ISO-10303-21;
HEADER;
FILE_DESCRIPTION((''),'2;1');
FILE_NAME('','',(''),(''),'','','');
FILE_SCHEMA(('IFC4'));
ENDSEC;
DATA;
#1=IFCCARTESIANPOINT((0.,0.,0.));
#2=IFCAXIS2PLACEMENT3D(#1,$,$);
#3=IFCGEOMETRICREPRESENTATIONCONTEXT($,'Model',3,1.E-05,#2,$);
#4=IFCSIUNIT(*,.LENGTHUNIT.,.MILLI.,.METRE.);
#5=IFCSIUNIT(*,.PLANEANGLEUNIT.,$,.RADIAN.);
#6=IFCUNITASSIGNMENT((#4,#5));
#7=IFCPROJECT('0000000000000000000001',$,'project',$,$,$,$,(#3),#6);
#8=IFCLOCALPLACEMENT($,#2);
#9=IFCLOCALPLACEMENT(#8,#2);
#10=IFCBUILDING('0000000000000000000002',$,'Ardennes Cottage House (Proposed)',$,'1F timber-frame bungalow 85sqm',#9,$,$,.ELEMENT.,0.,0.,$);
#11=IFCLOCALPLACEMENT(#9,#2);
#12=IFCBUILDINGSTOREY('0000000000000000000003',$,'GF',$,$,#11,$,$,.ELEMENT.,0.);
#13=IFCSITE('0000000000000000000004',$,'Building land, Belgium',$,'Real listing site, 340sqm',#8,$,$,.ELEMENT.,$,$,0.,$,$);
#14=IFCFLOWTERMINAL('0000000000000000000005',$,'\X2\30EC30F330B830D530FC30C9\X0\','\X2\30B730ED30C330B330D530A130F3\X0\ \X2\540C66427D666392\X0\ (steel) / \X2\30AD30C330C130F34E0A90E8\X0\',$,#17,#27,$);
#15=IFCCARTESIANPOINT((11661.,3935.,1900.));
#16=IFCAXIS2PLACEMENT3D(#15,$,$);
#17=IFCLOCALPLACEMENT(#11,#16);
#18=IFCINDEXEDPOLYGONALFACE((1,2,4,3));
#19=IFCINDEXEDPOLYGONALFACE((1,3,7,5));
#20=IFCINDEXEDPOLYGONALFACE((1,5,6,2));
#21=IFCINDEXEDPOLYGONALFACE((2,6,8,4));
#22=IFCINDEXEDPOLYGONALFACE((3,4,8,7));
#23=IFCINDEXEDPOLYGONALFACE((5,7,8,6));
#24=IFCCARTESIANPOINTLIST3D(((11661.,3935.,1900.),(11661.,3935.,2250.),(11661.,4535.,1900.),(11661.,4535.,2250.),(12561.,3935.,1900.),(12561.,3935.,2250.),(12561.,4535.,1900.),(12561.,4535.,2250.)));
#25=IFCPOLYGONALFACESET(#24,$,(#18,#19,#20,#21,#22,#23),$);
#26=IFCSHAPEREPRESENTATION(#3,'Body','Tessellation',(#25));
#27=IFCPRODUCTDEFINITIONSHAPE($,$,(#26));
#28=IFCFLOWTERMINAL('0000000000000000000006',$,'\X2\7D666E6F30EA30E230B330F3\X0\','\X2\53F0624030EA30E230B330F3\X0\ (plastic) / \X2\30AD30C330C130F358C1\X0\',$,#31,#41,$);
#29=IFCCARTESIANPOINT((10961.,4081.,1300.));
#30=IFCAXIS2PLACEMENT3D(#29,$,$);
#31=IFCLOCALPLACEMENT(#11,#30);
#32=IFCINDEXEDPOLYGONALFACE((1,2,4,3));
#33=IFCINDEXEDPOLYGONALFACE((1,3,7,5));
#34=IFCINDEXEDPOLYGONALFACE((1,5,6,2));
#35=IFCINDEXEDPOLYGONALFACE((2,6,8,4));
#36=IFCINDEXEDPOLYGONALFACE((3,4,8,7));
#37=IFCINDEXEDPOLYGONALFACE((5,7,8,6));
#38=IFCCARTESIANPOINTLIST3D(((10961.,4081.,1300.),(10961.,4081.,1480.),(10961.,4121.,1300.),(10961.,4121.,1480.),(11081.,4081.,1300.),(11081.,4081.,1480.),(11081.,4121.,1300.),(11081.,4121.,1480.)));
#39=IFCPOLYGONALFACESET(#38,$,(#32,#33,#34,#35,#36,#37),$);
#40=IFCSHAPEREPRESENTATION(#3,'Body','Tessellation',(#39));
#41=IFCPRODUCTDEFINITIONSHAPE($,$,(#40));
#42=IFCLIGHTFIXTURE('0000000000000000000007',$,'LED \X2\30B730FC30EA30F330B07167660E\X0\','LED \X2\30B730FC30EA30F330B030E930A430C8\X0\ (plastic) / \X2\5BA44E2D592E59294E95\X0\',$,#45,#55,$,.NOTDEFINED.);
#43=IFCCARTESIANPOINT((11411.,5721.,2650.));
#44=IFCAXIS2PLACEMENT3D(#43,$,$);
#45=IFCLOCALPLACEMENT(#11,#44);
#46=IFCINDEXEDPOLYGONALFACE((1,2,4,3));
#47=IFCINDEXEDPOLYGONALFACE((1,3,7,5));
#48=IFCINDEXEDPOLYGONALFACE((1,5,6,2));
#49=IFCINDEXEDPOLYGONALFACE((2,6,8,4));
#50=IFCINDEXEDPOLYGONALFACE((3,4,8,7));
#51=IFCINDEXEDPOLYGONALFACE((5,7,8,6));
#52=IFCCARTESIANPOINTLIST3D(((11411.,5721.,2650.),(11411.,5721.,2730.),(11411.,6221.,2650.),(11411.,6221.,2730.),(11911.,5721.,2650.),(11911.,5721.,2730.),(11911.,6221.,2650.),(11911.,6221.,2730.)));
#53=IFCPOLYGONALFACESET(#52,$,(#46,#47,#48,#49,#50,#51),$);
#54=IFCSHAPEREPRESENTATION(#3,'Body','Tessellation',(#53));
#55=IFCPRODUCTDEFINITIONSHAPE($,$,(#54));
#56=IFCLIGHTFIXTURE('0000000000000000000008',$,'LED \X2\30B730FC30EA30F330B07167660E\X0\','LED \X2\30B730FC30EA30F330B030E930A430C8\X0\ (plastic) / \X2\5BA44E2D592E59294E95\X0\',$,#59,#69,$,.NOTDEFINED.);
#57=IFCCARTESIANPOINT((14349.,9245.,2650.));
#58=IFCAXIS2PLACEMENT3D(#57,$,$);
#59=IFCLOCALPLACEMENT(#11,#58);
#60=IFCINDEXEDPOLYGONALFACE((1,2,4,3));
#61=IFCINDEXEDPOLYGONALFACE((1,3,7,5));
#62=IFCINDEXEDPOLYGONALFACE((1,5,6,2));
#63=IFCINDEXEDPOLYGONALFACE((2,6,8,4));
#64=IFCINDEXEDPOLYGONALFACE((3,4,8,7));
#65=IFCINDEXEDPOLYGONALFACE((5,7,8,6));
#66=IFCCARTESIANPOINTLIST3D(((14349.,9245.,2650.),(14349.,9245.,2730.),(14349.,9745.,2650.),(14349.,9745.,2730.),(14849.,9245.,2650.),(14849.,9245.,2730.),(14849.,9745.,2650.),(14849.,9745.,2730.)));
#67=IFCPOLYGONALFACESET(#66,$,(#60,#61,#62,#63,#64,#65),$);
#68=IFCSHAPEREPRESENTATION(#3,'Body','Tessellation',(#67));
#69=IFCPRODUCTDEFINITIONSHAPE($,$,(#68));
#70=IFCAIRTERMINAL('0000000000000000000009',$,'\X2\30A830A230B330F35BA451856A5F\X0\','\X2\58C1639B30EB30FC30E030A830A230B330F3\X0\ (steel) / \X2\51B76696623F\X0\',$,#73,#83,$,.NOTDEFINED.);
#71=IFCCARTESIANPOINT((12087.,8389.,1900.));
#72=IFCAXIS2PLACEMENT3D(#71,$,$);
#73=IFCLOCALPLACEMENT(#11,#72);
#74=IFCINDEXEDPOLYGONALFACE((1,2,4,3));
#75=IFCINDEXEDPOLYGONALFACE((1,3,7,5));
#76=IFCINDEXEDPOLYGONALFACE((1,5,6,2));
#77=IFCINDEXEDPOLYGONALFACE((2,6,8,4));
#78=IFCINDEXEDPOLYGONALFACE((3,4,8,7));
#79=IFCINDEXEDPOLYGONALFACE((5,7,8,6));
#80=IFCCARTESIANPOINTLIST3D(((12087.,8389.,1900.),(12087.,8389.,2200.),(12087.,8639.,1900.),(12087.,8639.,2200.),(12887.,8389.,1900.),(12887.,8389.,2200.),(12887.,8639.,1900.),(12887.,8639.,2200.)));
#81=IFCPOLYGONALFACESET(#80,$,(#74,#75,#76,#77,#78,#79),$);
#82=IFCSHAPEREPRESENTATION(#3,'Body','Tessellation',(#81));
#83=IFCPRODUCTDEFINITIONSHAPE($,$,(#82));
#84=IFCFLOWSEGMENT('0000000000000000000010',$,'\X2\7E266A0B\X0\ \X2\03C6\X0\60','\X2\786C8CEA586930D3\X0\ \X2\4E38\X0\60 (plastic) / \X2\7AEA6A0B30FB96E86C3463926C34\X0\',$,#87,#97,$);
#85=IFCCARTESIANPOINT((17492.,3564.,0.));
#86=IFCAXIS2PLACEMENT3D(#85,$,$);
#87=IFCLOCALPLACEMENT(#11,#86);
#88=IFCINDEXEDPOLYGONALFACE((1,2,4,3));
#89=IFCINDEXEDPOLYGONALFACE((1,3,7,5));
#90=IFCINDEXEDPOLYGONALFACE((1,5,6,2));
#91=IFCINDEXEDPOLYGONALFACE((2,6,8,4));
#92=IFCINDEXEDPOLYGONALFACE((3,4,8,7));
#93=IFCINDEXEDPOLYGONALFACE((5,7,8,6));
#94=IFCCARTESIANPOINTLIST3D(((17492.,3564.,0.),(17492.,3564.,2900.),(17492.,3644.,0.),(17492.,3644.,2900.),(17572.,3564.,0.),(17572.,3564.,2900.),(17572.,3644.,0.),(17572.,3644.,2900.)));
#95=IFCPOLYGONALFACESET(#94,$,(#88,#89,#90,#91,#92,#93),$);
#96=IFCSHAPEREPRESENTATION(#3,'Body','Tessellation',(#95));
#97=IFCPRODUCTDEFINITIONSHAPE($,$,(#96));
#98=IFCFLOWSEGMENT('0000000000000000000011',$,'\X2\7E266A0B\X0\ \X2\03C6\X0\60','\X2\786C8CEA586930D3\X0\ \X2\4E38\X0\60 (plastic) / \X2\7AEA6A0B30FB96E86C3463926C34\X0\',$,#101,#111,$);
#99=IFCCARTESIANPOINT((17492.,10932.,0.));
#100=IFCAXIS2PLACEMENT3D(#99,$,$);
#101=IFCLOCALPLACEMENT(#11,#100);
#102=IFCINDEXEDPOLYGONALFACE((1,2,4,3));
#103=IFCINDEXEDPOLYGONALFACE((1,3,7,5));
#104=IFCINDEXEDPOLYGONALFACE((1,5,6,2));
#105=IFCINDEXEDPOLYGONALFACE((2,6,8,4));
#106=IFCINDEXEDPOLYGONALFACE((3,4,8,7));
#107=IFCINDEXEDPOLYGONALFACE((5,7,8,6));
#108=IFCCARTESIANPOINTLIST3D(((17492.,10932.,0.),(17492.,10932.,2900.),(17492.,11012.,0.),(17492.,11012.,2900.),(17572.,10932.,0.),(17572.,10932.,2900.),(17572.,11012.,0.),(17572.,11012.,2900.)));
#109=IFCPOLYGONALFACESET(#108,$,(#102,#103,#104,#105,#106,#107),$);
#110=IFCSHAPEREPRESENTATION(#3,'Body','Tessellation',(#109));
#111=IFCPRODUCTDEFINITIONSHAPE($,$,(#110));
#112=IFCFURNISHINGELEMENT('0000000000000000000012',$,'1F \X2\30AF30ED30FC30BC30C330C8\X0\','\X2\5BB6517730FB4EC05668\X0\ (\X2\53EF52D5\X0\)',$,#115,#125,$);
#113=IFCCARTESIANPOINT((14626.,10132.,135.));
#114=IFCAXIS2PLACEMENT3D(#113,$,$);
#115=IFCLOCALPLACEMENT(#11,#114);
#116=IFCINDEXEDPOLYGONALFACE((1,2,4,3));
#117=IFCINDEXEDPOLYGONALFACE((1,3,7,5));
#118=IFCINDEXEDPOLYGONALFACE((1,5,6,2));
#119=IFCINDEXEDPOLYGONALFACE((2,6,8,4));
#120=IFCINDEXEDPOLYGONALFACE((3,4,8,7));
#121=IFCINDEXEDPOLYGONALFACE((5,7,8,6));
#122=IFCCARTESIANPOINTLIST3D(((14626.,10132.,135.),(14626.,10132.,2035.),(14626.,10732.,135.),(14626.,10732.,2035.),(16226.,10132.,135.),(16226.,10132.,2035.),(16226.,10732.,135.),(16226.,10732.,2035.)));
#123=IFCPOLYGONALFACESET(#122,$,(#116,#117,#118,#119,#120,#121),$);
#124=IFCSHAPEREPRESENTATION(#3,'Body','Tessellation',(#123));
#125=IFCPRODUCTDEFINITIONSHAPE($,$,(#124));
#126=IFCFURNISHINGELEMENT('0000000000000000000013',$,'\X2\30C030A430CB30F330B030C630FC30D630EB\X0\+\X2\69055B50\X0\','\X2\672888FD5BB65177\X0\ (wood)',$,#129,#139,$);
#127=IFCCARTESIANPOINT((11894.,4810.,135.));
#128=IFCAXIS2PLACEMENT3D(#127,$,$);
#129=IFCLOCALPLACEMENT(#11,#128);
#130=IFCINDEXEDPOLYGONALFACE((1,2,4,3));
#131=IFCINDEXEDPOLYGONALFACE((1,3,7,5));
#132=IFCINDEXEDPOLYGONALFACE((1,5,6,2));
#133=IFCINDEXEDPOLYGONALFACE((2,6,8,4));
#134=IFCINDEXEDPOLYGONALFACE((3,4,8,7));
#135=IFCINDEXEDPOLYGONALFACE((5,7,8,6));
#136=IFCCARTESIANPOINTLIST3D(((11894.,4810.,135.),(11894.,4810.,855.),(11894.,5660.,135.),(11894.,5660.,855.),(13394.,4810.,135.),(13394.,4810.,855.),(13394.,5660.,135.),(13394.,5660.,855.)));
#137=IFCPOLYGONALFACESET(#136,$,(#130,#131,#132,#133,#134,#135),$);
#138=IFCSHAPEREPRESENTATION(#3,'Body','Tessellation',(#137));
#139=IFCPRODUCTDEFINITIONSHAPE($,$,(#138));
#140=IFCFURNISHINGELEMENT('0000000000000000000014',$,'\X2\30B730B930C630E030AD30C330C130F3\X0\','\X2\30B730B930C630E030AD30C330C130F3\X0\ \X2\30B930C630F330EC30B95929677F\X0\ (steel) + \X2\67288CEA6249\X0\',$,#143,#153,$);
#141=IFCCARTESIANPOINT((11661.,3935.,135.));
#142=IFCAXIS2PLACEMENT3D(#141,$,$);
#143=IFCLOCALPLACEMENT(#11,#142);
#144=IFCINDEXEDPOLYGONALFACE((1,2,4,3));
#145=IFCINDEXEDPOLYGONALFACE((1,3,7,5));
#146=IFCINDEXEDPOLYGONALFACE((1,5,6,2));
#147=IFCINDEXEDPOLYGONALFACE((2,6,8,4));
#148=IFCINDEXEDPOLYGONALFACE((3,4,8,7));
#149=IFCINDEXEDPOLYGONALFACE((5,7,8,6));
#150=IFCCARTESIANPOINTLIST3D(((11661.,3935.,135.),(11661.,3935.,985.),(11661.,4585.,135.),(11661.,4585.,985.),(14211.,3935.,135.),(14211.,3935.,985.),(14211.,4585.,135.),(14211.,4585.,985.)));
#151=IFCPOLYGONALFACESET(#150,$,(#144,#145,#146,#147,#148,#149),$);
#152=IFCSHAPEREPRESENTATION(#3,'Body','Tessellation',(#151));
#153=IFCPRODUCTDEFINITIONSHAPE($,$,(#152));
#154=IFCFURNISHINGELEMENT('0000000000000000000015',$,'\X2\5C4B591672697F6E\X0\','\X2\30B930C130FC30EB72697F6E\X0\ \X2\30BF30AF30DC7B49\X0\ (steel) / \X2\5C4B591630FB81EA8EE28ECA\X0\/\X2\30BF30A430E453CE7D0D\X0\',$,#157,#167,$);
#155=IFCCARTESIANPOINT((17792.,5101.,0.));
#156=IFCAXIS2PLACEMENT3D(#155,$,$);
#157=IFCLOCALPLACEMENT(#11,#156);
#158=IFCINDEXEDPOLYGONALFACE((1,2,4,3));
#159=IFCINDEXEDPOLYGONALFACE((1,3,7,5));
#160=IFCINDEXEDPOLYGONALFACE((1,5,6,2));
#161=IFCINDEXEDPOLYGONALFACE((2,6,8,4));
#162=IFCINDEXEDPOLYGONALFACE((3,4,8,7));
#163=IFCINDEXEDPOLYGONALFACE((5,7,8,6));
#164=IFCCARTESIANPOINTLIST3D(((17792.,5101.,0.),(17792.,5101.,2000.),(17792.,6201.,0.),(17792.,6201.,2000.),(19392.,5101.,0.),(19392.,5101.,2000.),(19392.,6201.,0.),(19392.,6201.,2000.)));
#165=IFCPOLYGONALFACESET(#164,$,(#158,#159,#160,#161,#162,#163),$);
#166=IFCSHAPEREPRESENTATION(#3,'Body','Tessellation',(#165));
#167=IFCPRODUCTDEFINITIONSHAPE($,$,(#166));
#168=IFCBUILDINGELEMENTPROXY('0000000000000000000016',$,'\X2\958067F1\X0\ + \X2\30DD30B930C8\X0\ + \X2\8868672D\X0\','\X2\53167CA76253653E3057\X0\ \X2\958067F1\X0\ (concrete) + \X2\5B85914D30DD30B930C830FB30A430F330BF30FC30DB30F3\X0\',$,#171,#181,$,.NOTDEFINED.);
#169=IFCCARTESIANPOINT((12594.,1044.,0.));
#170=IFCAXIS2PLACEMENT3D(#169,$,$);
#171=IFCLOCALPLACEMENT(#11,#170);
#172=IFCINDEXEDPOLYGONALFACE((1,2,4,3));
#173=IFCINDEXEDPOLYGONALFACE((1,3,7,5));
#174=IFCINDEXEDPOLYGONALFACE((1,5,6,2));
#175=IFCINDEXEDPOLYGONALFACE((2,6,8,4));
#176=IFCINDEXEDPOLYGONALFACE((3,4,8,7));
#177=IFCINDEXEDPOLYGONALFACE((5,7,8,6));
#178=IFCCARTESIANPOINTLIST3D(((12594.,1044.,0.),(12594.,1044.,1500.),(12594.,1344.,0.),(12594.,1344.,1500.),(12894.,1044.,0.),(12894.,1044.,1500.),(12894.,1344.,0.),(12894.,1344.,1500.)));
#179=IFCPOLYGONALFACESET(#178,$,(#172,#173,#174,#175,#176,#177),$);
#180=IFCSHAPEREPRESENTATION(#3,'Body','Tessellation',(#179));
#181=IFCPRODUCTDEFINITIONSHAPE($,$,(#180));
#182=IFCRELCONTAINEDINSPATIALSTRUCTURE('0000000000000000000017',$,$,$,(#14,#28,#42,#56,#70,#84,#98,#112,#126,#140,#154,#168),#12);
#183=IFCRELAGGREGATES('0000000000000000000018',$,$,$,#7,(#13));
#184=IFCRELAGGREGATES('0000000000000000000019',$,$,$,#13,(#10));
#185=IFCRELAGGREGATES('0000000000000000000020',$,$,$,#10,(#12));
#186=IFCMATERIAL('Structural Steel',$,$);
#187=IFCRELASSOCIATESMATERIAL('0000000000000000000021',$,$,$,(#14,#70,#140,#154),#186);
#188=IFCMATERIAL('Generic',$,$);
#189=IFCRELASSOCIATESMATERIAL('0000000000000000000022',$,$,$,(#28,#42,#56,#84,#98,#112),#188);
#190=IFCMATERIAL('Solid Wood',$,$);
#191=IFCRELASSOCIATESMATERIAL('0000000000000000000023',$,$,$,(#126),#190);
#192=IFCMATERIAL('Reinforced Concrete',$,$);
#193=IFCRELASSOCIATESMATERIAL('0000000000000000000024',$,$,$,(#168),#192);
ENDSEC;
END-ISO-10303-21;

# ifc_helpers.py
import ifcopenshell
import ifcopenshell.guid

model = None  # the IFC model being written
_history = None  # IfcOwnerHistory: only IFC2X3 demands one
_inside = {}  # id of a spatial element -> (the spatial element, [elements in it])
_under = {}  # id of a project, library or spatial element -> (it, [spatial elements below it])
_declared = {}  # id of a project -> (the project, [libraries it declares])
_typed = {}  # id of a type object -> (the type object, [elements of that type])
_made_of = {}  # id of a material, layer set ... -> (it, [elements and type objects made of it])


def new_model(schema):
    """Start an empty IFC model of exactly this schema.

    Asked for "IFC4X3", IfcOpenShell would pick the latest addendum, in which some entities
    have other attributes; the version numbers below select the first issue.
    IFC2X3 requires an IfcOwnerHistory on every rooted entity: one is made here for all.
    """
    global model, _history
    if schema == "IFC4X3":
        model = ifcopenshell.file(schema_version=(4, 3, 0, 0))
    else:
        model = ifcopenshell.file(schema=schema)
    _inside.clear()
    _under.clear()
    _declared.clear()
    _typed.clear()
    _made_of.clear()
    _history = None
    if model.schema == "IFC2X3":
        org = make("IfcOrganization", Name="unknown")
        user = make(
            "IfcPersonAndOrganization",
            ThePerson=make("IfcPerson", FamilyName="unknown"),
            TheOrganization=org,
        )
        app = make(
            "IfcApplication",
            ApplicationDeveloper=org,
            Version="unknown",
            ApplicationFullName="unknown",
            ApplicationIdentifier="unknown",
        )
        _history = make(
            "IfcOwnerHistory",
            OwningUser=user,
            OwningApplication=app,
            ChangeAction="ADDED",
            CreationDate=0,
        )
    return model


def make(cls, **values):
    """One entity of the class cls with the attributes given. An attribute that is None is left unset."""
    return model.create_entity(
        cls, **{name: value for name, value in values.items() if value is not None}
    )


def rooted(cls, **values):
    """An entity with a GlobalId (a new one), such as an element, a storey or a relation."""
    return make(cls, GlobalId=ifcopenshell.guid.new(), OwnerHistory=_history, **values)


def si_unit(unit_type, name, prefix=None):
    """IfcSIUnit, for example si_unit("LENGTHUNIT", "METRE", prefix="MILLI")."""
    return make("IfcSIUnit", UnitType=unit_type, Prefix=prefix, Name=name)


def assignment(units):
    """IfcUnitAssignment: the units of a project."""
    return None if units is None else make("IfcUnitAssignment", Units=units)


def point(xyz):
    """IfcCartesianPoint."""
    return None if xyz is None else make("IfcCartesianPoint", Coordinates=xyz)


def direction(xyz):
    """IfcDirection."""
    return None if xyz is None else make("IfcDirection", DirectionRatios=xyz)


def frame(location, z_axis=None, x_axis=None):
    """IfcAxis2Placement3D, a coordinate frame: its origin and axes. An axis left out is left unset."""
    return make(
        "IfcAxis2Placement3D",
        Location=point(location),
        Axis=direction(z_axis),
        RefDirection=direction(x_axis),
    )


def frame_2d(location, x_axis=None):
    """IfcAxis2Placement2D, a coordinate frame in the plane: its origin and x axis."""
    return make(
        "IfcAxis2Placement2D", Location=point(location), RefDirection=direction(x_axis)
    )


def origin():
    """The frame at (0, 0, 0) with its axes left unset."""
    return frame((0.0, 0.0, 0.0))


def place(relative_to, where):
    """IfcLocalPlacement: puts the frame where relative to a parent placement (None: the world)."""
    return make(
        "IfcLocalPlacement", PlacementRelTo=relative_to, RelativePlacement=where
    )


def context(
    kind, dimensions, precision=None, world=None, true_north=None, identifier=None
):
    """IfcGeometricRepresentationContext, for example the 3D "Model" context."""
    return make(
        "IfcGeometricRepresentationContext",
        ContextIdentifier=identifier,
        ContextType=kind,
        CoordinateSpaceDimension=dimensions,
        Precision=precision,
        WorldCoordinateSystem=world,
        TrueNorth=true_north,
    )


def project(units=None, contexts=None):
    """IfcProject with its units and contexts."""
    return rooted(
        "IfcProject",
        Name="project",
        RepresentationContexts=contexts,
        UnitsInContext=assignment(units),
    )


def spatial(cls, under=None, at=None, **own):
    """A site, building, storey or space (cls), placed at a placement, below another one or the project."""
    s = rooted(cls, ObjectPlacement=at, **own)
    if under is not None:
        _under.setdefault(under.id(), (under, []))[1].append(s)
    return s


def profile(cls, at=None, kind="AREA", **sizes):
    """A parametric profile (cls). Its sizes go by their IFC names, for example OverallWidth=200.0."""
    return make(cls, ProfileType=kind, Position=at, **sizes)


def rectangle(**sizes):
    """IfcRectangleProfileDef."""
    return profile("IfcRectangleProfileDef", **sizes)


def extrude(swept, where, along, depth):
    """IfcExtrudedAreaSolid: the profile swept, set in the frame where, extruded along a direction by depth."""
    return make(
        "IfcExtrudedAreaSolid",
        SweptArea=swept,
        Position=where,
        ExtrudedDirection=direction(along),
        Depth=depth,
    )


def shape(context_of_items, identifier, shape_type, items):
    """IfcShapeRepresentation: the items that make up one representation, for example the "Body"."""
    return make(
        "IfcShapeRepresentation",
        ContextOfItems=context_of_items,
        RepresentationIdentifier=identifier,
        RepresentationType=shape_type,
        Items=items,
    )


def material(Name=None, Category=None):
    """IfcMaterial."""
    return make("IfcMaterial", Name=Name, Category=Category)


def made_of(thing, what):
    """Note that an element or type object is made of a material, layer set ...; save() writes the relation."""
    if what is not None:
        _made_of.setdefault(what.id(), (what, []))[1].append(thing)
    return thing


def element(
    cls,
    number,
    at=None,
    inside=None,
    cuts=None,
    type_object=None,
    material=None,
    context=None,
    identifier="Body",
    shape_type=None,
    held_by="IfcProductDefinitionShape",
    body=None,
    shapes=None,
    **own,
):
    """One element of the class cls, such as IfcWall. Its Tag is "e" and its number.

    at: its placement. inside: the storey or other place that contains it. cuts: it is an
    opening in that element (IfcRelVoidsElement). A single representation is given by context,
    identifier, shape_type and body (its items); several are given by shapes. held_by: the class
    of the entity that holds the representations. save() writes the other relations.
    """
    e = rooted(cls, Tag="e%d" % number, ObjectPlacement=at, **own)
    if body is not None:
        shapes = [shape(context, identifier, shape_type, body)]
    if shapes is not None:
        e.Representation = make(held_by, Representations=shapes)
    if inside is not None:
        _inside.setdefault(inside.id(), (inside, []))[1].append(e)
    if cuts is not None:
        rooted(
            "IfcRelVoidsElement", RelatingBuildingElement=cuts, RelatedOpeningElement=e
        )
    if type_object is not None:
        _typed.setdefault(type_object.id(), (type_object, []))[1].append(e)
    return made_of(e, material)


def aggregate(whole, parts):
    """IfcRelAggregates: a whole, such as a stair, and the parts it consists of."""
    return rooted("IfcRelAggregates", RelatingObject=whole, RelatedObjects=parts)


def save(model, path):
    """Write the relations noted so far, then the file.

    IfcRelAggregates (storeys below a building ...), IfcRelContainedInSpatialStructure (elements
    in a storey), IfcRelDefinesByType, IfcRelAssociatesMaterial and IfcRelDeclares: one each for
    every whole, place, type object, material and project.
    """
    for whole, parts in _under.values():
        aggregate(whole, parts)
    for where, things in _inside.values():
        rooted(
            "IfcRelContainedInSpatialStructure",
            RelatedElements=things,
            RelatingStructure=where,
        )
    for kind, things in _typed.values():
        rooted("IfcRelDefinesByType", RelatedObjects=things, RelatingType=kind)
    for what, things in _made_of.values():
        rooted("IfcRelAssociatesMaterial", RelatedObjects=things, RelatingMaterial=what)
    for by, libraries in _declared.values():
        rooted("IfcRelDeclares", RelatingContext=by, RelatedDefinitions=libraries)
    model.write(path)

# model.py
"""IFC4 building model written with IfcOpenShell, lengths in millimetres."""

from ifc_helpers import new_model, si_unit, frame, frame_2d, origin, place, context, project, spatial, rectangle, extrude, material, element, save


model = new_model("IFC4")

# Units and contexts
model_context = context("Model", 3, precision=1e-05, world=origin())
ifc_project = project(units=[si_unit("LENGTHUNIT", "METRE", prefix="MILLI"), si_unit("PLANEANGLEUNIT", "RADIAN")], contexts=[model_context])

# Site, building, storey
site_placement = place(None, origin())
site = spatial("IfcSite", under=ifc_project, at=site_placement, Name="Building land, Belgium", ObjectType="Real listing site, 340sqm", CompositionType="ELEMENT", RefElevation=0.0)
building_placement = place(site_placement, origin())
building = spatial("IfcBuilding", under=site, at=building_placement, Name="Ardennes Cottage House (Proposed)", ObjectType="1F timber-frame bungalow 85sqm", CompositionType="ELEMENT", ElevationOfRefHeight=0.0, ElevationOfTerrain=0.0)
storey_placement = place(building_placement, origin())
storey = spatial("IfcBuildingStorey", under=building, at=storey_placement, Name="GF", CompositionType="ELEMENT", Elevation=0.0)

# Shared definitions
ifc_material_1 = material(Name="Solid Wood")

# Shared definitions
ifc_material_2 = material(Name="Reinforced Concrete")

# Shared definitions
ifc_material_3 = material(Name="Generic")

# Shared definitions
ifc_material_4 = material(Name="Structural Steel")

# Flow terminals
flow_terminal_1_placement = place(storey_placement, frame((11661.0, 3935.0, 1900.0)))
element("IfcFlowTerminal", 1, at=flow_terminal_1_placement, inside=storey, material=ifc_material_4, Name="レンジフード", Description="シロッコファン 同時給排 (steel) / キッチン上部", context=model_context, shape_type="SweptSolid", body=[
    extrude(rectangle(XDim=900.0, YDim=600.0, at=frame_2d((450.0, 300.0))), frame((11661.0, 3935.0, 1900.0)), (0.0, 0.0, 1.0), 350.0),
])
flow_terminal_2_placement = place(storey_placement, frame((10961.0, 4081.0, 1300.0)))
element("IfcFlowTerminal", 2, at=flow_terminal_2_placement, inside=storey, material=ifc_material_3, Name="給湯リモコン", Description="台所リモコン (plastic) / キッチン壁", context=model_context, shape_type="SweptSolid", body=[
    extrude(rectangle(XDim=120.0, YDim=40.0, at=frame_2d((60.0, 20.0))), frame((10961.0, 4081.0, 1300.0)), (0.0, 0.0, 1.0), 180.0),
])

# Light fixtures
light_fixture_1_placement = place(storey_placement, frame((11411.0, 5721.0, 2650.0)))
element("IfcLightFixture", 3, at=light_fixture_1_placement, inside=storey, material=ifc_material_3, Name="LED シーリング照明", Description="LED シーリングライト (plastic) / 室中央天井", PredefinedType="NOTDEFINED", context=model_context, shape_type="SweptSolid", body=[
    extrude(rectangle(XDim=500.0, YDim=500.0, at=frame_2d((250.0, 250.0))), frame((11411.0, 5721.0, 2650.0)), (0.0, 0.0, 1.0), 80.0),
])
light_fixture_2_placement = place(storey_placement, frame((14349.0, 9245.0, 2650.0)))
element("IfcLightFixture", 4, at=light_fixture_2_placement, inside=storey, material=ifc_material_3, Name="LED シーリング照明", Description="LED シーリングライト (plastic) / 室中央天井", PredefinedType="NOTDEFINED", context=model_context, shape_type="SweptSolid", body=[
    extrude(rectangle(XDim=500.0, YDim=500.0, at=frame_2d((250.0, 250.0))), frame((14349.0, 9245.0, 2650.0)), (0.0, 0.0, 1.0), 80.0),
])

# Air terminal
air_terminal_placement = place(storey_placement, frame((12087.0, 8389.0, 1900.0)))
element("IfcAirTerminal", 5, at=air_terminal_placement, inside=storey, material=ifc_material_4, Name="エアコン室内機", Description="壁掛ルームエアコン (steel) / 冷暖房", PredefinedType="NOTDEFINED", context=model_context, shape_type="SweptSolid", body=[
    extrude(rectangle(XDim=800.0, YDim=250.0, at=frame_2d((400.0, 125.0))), frame((12087.0, 8389.0, 1900.0)), (0.0, 0.0, 1.0), 300.0),
])

# Flow segments
flow_segment_1_placement = place(storey_placement, frame((17492.0, 3564.0, 0.0)))
element("IfcFlowSegment", 6, at=flow_segment_1_placement, inside=storey, material=ifc_material_3, Name="縦樋 φ60", Description="硬質塩ビ 丸60 (plastic) / 竪樋・雨水排水", context=model_context, shape_type="SweptSolid", body=[
    extrude(rectangle(XDim=80.0, YDim=80.0, at=frame_2d((40.0, 40.0))), frame((17492.0, 3564.0, 0.0)), (0.0, 0.0, 1.0), 2900.0),
])
flow_segment_2_placement = place(storey_placement, frame((17492.0, 10932.0, 0.0)))
element("IfcFlowSegment", 7, at=flow_segment_2_placement, inside=storey, material=ifc_material_3, Name="縦樋 φ60", Description="硬質塩ビ 丸60 (plastic) / 竪樋・雨水排水", context=model_context, shape_type="SweptSolid", body=[
    extrude(rectangle(XDim=80.0, YDim=80.0, at=frame_2d((40.0, 40.0))), frame((17492.0, 10932.0, 0.0)), (0.0, 0.0, 1.0), 2900.0),
])

# Furnishing elements
furnishing_1_placement = place(storey_placement, frame((14626.0, 10132.0, 135.0)))
element("IfcFurnishingElement", 8, at=furnishing_1_placement, inside=storey, material=ifc_material_3, Name="1F クローゼット", Description="家具・什器 (可動)", context=model_context, shape_type="SweptSolid", body=[
    extrude(rectangle(XDim=1600.0, YDim=600.0, at=frame_2d((800.0, 300.0))), frame((14626.0, 10132.0, 135.0)), (0.0, 0.0, 1.0), 1900.0),
])
furnishing_2_placement = place(storey_placement, frame((11894.0, 4810.0, 135.0)))
element("IfcFurnishingElement", 9, at=furnishing_2_placement, inside=storey, material=ifc_material_1, Name="ダイニングテーブル+椅子", Description="木製家具 (wood)", context=model_context, shape_type="SweptSolid", body=[
    extrude(rectangle(XDim=1500.0, YDim=850.0, at=frame_2d((750.0, 425.0))), frame((11894.0, 4810.0, 135.0)), (0.0, 0.0, 1.0), 720.0),
])
furnishing_3_placement = place(storey_placement, frame((11661.0, 3935.0, 135.0)))
element("IfcFurnishingElement", 10, at=furnishing_3_placement, inside=storey, material=ifc_material_4, Name="システムキッチン", Description="システムキッチン ステンレス天板 (steel) + 木質扉", context=model_context, shape_type="SweptSolid", body=[
    extrude(rectangle(XDim=2550.0, YDim=650.0, at=frame_2d((1275.0, 325.0))), frame((11661.0, 3935.0, 135.0)), (0.0, 0.0, 1.0), 850.0),
])
furnishing_4_placement = place(storey_placement, frame((17792.0, 5101.0, 0.0)))
element("IfcFurnishingElement", 11, at=furnishing_4_placement, inside=storey, material=ifc_material_4, Name="屋外物置", Description="スチール物置 タクボ等 (steel) / 屋外・自転車/タイヤ収納", context=model_context, shape_type="SweptSolid", body=[
    extrude(rectangle(XDim=1600.0, YDim=1100.0, at=frame_2d((800.0, 550.0))), frame((17792.0, 5101.0, 0.0)), (0.0, 0.0, 1.0), 2000.0),
])

# Building element proxy
proxy_placement = place(storey_placement, frame((12594.0, 1044.0, 0.0)))
element("IfcBuildingElementProxy", 12, at=proxy_placement, inside=storey, material=ifc_material_2, Name="門柱 + ポスト + 表札", Description="化粧打放し 門柱 (concrete) + 宅配ポスト・インターホン", PredefinedType="NOTDEFINED", context=model_context, shape_type="SweptSolid", body=[
    extrude(rectangle(XDim=300.0, YDim=300.0, at=frame_2d((150.0, 150.0))), frame((12594.0, 1044.0, 0.0)), (0.0, 0.0, 1.0), 1500.0),
])

save(model, "model.ifc")
